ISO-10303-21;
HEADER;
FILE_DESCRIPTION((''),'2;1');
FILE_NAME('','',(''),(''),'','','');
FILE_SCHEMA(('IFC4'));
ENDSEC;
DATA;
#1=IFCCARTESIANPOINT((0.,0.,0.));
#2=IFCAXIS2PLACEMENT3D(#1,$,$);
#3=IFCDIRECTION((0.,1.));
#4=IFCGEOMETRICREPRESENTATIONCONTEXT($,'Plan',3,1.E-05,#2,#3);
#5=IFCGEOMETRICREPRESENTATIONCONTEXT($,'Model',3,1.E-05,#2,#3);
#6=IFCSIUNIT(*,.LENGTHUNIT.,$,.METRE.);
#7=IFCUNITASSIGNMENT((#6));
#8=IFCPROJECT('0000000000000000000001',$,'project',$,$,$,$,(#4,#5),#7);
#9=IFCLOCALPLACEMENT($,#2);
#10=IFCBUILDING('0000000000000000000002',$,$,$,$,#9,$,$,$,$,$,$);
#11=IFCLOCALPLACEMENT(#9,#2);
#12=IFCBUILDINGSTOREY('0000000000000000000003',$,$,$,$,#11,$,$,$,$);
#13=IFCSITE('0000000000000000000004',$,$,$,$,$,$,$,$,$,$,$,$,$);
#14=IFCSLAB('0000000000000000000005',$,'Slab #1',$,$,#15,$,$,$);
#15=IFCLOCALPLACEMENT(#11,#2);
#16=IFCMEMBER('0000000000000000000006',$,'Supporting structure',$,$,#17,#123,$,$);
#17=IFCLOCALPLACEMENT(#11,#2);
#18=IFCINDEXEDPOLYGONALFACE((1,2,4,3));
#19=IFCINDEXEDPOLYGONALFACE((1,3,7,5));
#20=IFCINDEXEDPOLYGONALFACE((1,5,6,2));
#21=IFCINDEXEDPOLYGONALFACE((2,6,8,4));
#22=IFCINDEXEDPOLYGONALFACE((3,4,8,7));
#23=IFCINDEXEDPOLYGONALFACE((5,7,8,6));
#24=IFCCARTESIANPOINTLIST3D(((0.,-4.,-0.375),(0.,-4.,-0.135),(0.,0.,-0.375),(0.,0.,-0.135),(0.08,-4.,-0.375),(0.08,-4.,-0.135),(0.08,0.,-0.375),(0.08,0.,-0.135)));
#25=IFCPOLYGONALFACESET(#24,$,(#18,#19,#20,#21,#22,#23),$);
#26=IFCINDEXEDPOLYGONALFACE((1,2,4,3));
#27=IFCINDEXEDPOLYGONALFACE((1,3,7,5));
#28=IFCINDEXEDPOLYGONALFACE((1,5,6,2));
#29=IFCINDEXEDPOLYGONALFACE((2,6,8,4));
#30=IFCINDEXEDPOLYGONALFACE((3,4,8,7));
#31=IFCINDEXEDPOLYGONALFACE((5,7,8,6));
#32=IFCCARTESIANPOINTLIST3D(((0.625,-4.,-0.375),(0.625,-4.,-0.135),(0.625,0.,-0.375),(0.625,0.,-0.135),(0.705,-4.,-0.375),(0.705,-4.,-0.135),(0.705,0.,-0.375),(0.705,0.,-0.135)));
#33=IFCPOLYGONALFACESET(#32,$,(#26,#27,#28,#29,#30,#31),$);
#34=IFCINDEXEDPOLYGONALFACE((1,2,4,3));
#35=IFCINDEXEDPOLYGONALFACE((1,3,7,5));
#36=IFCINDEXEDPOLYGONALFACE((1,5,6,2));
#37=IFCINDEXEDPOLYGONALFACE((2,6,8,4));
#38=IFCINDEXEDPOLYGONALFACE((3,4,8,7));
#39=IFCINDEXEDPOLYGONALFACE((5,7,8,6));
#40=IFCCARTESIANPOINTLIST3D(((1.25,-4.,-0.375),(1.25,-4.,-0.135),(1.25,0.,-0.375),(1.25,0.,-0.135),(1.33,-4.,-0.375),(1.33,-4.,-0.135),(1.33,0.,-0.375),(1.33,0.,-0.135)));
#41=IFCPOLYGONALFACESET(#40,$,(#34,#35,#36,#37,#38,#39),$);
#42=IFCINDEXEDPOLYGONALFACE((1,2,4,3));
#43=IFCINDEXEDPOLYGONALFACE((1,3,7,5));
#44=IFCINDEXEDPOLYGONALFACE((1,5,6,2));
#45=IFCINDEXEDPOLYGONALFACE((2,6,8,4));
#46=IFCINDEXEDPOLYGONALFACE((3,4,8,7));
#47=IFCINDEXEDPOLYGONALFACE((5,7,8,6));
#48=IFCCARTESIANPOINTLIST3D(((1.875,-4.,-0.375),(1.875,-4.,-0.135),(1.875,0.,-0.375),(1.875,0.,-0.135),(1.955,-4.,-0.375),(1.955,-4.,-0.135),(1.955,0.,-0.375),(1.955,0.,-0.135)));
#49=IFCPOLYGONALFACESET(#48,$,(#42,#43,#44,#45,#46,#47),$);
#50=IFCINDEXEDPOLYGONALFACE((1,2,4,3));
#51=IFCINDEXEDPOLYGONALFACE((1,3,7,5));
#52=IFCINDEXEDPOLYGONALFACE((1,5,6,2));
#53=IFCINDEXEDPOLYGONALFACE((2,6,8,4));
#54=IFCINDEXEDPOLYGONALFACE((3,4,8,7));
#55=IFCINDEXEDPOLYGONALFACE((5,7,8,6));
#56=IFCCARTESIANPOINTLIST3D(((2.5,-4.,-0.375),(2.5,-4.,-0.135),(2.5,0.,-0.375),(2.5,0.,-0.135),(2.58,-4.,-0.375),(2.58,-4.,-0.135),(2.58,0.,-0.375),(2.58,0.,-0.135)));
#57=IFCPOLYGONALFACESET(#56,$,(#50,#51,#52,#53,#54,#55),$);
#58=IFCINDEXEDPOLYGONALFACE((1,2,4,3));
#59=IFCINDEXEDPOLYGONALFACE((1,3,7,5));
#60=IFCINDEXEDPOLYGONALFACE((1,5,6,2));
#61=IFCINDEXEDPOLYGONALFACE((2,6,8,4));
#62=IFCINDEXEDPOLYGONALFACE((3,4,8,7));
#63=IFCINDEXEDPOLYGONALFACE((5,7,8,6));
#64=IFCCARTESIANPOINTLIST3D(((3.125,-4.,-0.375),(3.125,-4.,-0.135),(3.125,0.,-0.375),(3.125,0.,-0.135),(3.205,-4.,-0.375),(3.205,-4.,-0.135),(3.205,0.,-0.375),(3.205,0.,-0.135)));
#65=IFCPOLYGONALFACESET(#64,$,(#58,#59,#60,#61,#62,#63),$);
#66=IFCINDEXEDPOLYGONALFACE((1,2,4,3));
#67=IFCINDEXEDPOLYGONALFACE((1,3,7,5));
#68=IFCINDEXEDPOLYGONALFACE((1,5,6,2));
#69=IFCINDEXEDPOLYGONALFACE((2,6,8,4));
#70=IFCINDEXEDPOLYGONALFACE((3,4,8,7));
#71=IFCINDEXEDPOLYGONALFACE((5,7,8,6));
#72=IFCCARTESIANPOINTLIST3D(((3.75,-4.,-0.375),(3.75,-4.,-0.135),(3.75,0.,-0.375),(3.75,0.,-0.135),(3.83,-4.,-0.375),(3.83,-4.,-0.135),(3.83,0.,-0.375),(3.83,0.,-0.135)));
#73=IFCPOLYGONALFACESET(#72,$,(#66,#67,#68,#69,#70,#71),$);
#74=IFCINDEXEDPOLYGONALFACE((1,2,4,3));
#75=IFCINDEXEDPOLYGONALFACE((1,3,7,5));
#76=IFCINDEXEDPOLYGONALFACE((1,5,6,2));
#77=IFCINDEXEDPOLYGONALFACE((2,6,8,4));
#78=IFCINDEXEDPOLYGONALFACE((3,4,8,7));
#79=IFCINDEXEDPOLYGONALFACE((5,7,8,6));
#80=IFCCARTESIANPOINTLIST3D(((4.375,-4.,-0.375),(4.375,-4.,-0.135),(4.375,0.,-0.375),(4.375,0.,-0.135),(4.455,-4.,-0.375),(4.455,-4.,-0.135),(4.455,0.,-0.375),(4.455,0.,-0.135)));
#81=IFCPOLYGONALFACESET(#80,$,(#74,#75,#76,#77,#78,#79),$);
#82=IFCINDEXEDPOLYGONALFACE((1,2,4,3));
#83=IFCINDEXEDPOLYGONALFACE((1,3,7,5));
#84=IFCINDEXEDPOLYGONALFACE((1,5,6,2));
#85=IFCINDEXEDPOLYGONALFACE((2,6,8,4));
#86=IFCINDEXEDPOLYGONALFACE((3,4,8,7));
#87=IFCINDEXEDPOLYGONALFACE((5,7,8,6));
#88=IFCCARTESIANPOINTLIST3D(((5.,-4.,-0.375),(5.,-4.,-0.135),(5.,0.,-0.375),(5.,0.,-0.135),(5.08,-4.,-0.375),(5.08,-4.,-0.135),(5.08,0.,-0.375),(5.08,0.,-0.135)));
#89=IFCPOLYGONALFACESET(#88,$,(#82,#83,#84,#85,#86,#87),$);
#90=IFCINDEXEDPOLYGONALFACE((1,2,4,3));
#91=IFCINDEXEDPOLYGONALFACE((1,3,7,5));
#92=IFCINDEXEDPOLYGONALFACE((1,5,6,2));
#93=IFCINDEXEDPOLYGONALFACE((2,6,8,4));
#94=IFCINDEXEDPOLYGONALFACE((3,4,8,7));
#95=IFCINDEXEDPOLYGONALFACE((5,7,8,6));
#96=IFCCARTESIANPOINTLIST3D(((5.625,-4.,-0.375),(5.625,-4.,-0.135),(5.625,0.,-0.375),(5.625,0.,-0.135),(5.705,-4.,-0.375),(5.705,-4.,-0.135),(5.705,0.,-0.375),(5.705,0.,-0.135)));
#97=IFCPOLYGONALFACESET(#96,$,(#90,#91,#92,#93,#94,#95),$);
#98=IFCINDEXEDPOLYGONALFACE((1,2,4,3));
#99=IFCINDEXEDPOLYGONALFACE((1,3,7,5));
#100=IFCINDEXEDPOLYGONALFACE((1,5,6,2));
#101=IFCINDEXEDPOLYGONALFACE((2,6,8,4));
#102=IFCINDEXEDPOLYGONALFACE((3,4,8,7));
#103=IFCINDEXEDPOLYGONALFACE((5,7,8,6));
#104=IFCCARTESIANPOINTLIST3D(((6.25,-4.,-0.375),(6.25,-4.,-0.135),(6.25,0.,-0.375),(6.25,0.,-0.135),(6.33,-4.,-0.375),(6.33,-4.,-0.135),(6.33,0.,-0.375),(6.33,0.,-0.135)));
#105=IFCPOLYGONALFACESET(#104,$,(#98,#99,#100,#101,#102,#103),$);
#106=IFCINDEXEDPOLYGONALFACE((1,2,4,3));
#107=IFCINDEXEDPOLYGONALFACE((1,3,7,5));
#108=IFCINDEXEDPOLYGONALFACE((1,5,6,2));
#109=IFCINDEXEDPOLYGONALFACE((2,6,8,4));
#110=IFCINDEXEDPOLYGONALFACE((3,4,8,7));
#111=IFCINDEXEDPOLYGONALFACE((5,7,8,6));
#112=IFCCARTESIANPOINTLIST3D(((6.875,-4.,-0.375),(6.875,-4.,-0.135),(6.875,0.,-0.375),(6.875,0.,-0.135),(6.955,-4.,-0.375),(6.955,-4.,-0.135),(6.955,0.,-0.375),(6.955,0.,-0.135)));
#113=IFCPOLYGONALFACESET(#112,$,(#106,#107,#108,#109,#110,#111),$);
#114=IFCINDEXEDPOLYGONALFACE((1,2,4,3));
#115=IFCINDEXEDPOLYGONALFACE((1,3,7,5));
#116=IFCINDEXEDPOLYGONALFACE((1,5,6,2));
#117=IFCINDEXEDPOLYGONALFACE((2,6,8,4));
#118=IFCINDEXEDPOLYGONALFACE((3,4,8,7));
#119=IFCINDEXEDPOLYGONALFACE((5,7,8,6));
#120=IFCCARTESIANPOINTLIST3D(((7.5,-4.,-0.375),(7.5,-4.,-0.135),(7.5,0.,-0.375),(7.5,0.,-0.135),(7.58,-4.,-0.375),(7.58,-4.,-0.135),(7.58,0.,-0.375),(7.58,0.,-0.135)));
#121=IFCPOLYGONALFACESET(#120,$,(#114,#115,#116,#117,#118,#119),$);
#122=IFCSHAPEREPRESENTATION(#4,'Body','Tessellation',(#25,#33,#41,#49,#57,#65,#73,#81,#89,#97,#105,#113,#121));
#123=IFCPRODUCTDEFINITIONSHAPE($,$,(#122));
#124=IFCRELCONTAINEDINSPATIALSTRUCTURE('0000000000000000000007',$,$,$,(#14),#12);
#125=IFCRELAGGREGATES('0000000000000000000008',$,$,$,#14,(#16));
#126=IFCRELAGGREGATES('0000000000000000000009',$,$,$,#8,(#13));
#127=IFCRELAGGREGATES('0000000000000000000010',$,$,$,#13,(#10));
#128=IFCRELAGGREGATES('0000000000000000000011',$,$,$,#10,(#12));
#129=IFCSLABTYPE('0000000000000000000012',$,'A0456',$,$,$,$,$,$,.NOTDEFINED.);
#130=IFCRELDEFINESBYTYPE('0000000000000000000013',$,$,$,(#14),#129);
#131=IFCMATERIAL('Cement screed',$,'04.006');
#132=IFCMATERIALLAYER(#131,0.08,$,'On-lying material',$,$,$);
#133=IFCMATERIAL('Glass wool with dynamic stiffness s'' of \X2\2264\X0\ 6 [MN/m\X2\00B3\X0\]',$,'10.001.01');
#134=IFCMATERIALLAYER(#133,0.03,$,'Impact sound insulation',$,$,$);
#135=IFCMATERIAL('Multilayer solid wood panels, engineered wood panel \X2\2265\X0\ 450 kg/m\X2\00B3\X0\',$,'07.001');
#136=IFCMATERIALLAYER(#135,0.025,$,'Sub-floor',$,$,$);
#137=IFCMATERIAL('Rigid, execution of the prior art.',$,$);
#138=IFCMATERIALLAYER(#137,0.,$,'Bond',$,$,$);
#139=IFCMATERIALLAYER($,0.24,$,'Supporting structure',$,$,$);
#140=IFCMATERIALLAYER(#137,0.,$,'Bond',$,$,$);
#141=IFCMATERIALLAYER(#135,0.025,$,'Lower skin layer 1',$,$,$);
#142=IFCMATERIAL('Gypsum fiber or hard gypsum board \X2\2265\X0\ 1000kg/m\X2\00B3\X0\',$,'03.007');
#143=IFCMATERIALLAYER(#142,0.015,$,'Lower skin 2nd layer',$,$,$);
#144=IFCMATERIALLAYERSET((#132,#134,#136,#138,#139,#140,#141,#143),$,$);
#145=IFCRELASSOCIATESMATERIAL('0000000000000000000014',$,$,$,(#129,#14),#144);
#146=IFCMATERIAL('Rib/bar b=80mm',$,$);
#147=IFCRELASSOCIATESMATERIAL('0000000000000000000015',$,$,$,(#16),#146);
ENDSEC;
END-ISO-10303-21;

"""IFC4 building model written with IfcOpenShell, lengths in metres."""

from ifc_helpers import new_model, si_unit, direction, frame, frame_2d, origin, place, context, project, spatial, rectangle, extrude, material, layer, layer_set, type_object, element, aggregate, save


model = new_model("IFC4")

# Units and contexts
plan_context = context("Plan", 3, precision=1e-05, world=origin(), true_north=direction((0.0, 1.0)))
model_context = context("Model", 3, precision=1e-05, world=origin(), true_north=direction((0.0, 1.0)))
ifc_project = project(units=[si_unit("LENGTHUNIT", "METRE")], contexts=[plan_context, model_context])

# Site, building, storey
site = spatial("IfcSite", under=ifc_project)
building_placement = place(None, origin())
building = spatial("IfcBuilding", under=site, at=building_placement)
storey_placement = place(building_placement, origin())
storey = spatial("IfcBuildingStorey", under=building, at=storey_placement)

# Slab, member
ifc_material_1 = material(Name="Cement screed", Category="04.006")
ifc_layer_1 = layer(ifc_material_1, 0.08, Name="On-lying material")
ifc_material_2 = material(Name="Glass wool with dynamic stiffness s' of ≤ 6 [MN/m³]", Category="10.001.01")
ifc_layer_2 = layer(ifc_material_2, 0.03, Name="Impact sound insulation")
ifc_material_3 = material(Name="Multilayer solid wood panels, engineered wood panel ≥ 450 kg/m³", Category="07.001")
ifc_layer_3 = layer(ifc_material_3, 0.025, Name="Sub-floor")
ifc_material_4 = material(Name="Rigid, execution of the prior art.")
ifc_layer_4 = layer(ifc_material_4, 0.0, Name="Bond")
ifc_layer_5 = layer(None, 0.24, Name="Supporting structure")
ifc_layer_6 = layer(ifc_material_4, 0.0, Name="Bond")
ifc_layer_7 = layer(ifc_material_3, 0.025, Name="Lower skin layer 1")
ifc_material_5 = material(Name="Gypsum fiber or hard gypsum board ≥ 1000kg/m³", Category="03.007")
ifc_layer_8 = layer(ifc_material_5, 0.015, Name="Lower skin 2nd layer")
ifc_layer_set = layer_set([ifc_layer_1, ifc_layer_2, ifc_layer_3, ifc_layer_4, ifc_layer_5, ifc_layer_6, ifc_layer_7, ifc_layer_8])
slab_type = type_object("IfcSlabType", Name="A0456", PredefinedType="NOTDEFINED", material=ifc_layer_set)
slab_placement = place(None, frame((0.0, 0.0, 0.0), z_axis=(0.0, 0.0, -1.0), x_axis=(1.0, 0.0, 0.0)))
slab = element("IfcSlab", 1, at=slab_placement, inside=storey, type_object=slab_type, material=ifc_layer_set, Name="Slab #1")
ifc_material_6 = material(Name="Rib/bar b=80mm")
member_1_placement = place(slab_placement, origin())
member_1 = element("IfcMember", 2, at=member_1_placement, material=ifc_material_6, Name="Supporting structure", context=plan_context, shape_type="SweptSolid", body=[
    extrude(rectangle(XDim=0.08, YDim=0.24, at=frame_2d((0.04, 0.12), x_axis=(1.0, 0.0))), frame((0.0, 4.0, 0.135), z_axis=(0.0, -1.0, 0.0), x_axis=(1.0, 0.0, 0.0)), (0.0, 0.0, 1.0), 4.0),
    extrude(rectangle(XDim=0.08, YDim=0.24, at=frame_2d((0.04, 0.12), x_axis=(1.0, 0.0))), frame((0.625, 4.0, 0.135), z_axis=(0.0, -1.0, 0.0), x_axis=(1.0, 0.0, 0.0)), (0.0, 0.0, 1.0), 4.0),
    extrude(rectangle(XDim=0.08, YDim=0.24, at=frame_2d((0.04, 0.12), x_axis=(1.0, 0.0))), frame((1.25, 4.0, 0.135), z_axis=(0.0, -1.0, 0.0), x_axis=(1.0, 0.0, 0.0)), (0.0, 0.0, 1.0), 4.0),
    extrude(rectangle(XDim=0.08, YDim=0.24, at=frame_2d((0.04, 0.12), x_axis=(1.0, 0.0))), frame((1.875, 4.0, 0.135), z_axis=(0.0, -1.0, 0.0), x_axis=(1.0, 0.0, 0.0)), (0.0, 0.0, 1.0), 4.0),
    extrude(rectangle(XDim=0.08, YDim=0.24, at=frame_2d((0.04, 0.12), x_axis=(1.0, 0.0))), frame((2.5, 4.0, 0.135), z_axis=(0.0, -1.0, 0.0), x_axis=(1.0, 0.0, 0.0)), (0.0, 0.0, 1.0), 4.0),
    extrude(rectangle(XDim=0.08, YDim=0.24, at=frame_2d((0.04, 0.12), x_axis=(1.0, 0.0))), frame((3.125, 4.0, 0.135), z_axis=(0.0, -1.0, 0.0), x_axis=(1.0, 0.0, 0.0)), (0.0, 0.0, 1.0), 4.0),
    extrude(rectangle(XDim=0.08, YDim=0.24, at=frame_2d((0.04, 0.12), x_axis=(1.0, 0.0))), frame((3.75, 4.0, 0.135), z_axis=(0.0, -1.0, 0.0), x_axis=(1.0, 0.0, 0.0)), (0.0, 0.0, 1.0), 4.0),
    extrude(rectangle(XDim=0.08, YDim=0.24, at=frame_2d((0.04, 0.12), x_axis=(1.0, 0.0))), frame((4.375, 4.0, 0.135), z_axis=(0.0, -1.0, 0.0), x_axis=(1.0, 0.0, 0.0)), (0.0, 0.0, 1.0), 4.0),
    extrude(rectangle(XDim=0.08, YDim=0.24, at=frame_2d((0.04, 0.12), x_axis=(1.0, 0.0))), frame((5.0, 4.0, 0.135), z_axis=(0.0, -1.0, 0.0), x_axis=(1.0, 0.0, 0.0)), (0.0, 0.0, 1.0), 4.0),
    extrude(rectangle(XDim=0.08, YDim=0.24, at=frame_2d((0.04, 0.12), x_axis=(1.0, 0.0))), frame((5.625, 4.0, 0.135), z_axis=(0.0, -1.0, 0.0), x_axis=(1.0, 0.0, 0.0)), (0.0, 0.0, 1.0), 4.0),
    extrude(rectangle(XDim=0.08, YDim=0.24, at=frame_2d((0.04, 0.12), x_axis=(1.0, 0.0))), frame((6.25, 4.0, 0.135), z_axis=(0.0, -1.0, 0.0), x_axis=(1.0, 0.0, 0.0)), (0.0, 0.0, 1.0), 4.0),
    extrude(rectangle(XDim=0.08, YDim=0.24, at=frame_2d((0.04, 0.12), x_axis=(1.0, 0.0))), frame((6.875, 4.0, 0.135), z_axis=(0.0, -1.0, 0.0), x_axis=(1.0, 0.0, 0.0)), (0.0, 0.0, 1.0), 4.0),
    extrude(rectangle(XDim=0.08, YDim=0.24, at=frame_2d((0.04, 0.12), x_axis=(1.0, 0.0))), frame((7.5, 4.0, 0.135), z_axis=(0.0, -1.0, 0.0), x_axis=(1.0, 0.0, 0.0)), (0.0, 0.0, 1.0), 4.0),
])
aggregate(slab, [member_1])

save(model, "model.ifc")
